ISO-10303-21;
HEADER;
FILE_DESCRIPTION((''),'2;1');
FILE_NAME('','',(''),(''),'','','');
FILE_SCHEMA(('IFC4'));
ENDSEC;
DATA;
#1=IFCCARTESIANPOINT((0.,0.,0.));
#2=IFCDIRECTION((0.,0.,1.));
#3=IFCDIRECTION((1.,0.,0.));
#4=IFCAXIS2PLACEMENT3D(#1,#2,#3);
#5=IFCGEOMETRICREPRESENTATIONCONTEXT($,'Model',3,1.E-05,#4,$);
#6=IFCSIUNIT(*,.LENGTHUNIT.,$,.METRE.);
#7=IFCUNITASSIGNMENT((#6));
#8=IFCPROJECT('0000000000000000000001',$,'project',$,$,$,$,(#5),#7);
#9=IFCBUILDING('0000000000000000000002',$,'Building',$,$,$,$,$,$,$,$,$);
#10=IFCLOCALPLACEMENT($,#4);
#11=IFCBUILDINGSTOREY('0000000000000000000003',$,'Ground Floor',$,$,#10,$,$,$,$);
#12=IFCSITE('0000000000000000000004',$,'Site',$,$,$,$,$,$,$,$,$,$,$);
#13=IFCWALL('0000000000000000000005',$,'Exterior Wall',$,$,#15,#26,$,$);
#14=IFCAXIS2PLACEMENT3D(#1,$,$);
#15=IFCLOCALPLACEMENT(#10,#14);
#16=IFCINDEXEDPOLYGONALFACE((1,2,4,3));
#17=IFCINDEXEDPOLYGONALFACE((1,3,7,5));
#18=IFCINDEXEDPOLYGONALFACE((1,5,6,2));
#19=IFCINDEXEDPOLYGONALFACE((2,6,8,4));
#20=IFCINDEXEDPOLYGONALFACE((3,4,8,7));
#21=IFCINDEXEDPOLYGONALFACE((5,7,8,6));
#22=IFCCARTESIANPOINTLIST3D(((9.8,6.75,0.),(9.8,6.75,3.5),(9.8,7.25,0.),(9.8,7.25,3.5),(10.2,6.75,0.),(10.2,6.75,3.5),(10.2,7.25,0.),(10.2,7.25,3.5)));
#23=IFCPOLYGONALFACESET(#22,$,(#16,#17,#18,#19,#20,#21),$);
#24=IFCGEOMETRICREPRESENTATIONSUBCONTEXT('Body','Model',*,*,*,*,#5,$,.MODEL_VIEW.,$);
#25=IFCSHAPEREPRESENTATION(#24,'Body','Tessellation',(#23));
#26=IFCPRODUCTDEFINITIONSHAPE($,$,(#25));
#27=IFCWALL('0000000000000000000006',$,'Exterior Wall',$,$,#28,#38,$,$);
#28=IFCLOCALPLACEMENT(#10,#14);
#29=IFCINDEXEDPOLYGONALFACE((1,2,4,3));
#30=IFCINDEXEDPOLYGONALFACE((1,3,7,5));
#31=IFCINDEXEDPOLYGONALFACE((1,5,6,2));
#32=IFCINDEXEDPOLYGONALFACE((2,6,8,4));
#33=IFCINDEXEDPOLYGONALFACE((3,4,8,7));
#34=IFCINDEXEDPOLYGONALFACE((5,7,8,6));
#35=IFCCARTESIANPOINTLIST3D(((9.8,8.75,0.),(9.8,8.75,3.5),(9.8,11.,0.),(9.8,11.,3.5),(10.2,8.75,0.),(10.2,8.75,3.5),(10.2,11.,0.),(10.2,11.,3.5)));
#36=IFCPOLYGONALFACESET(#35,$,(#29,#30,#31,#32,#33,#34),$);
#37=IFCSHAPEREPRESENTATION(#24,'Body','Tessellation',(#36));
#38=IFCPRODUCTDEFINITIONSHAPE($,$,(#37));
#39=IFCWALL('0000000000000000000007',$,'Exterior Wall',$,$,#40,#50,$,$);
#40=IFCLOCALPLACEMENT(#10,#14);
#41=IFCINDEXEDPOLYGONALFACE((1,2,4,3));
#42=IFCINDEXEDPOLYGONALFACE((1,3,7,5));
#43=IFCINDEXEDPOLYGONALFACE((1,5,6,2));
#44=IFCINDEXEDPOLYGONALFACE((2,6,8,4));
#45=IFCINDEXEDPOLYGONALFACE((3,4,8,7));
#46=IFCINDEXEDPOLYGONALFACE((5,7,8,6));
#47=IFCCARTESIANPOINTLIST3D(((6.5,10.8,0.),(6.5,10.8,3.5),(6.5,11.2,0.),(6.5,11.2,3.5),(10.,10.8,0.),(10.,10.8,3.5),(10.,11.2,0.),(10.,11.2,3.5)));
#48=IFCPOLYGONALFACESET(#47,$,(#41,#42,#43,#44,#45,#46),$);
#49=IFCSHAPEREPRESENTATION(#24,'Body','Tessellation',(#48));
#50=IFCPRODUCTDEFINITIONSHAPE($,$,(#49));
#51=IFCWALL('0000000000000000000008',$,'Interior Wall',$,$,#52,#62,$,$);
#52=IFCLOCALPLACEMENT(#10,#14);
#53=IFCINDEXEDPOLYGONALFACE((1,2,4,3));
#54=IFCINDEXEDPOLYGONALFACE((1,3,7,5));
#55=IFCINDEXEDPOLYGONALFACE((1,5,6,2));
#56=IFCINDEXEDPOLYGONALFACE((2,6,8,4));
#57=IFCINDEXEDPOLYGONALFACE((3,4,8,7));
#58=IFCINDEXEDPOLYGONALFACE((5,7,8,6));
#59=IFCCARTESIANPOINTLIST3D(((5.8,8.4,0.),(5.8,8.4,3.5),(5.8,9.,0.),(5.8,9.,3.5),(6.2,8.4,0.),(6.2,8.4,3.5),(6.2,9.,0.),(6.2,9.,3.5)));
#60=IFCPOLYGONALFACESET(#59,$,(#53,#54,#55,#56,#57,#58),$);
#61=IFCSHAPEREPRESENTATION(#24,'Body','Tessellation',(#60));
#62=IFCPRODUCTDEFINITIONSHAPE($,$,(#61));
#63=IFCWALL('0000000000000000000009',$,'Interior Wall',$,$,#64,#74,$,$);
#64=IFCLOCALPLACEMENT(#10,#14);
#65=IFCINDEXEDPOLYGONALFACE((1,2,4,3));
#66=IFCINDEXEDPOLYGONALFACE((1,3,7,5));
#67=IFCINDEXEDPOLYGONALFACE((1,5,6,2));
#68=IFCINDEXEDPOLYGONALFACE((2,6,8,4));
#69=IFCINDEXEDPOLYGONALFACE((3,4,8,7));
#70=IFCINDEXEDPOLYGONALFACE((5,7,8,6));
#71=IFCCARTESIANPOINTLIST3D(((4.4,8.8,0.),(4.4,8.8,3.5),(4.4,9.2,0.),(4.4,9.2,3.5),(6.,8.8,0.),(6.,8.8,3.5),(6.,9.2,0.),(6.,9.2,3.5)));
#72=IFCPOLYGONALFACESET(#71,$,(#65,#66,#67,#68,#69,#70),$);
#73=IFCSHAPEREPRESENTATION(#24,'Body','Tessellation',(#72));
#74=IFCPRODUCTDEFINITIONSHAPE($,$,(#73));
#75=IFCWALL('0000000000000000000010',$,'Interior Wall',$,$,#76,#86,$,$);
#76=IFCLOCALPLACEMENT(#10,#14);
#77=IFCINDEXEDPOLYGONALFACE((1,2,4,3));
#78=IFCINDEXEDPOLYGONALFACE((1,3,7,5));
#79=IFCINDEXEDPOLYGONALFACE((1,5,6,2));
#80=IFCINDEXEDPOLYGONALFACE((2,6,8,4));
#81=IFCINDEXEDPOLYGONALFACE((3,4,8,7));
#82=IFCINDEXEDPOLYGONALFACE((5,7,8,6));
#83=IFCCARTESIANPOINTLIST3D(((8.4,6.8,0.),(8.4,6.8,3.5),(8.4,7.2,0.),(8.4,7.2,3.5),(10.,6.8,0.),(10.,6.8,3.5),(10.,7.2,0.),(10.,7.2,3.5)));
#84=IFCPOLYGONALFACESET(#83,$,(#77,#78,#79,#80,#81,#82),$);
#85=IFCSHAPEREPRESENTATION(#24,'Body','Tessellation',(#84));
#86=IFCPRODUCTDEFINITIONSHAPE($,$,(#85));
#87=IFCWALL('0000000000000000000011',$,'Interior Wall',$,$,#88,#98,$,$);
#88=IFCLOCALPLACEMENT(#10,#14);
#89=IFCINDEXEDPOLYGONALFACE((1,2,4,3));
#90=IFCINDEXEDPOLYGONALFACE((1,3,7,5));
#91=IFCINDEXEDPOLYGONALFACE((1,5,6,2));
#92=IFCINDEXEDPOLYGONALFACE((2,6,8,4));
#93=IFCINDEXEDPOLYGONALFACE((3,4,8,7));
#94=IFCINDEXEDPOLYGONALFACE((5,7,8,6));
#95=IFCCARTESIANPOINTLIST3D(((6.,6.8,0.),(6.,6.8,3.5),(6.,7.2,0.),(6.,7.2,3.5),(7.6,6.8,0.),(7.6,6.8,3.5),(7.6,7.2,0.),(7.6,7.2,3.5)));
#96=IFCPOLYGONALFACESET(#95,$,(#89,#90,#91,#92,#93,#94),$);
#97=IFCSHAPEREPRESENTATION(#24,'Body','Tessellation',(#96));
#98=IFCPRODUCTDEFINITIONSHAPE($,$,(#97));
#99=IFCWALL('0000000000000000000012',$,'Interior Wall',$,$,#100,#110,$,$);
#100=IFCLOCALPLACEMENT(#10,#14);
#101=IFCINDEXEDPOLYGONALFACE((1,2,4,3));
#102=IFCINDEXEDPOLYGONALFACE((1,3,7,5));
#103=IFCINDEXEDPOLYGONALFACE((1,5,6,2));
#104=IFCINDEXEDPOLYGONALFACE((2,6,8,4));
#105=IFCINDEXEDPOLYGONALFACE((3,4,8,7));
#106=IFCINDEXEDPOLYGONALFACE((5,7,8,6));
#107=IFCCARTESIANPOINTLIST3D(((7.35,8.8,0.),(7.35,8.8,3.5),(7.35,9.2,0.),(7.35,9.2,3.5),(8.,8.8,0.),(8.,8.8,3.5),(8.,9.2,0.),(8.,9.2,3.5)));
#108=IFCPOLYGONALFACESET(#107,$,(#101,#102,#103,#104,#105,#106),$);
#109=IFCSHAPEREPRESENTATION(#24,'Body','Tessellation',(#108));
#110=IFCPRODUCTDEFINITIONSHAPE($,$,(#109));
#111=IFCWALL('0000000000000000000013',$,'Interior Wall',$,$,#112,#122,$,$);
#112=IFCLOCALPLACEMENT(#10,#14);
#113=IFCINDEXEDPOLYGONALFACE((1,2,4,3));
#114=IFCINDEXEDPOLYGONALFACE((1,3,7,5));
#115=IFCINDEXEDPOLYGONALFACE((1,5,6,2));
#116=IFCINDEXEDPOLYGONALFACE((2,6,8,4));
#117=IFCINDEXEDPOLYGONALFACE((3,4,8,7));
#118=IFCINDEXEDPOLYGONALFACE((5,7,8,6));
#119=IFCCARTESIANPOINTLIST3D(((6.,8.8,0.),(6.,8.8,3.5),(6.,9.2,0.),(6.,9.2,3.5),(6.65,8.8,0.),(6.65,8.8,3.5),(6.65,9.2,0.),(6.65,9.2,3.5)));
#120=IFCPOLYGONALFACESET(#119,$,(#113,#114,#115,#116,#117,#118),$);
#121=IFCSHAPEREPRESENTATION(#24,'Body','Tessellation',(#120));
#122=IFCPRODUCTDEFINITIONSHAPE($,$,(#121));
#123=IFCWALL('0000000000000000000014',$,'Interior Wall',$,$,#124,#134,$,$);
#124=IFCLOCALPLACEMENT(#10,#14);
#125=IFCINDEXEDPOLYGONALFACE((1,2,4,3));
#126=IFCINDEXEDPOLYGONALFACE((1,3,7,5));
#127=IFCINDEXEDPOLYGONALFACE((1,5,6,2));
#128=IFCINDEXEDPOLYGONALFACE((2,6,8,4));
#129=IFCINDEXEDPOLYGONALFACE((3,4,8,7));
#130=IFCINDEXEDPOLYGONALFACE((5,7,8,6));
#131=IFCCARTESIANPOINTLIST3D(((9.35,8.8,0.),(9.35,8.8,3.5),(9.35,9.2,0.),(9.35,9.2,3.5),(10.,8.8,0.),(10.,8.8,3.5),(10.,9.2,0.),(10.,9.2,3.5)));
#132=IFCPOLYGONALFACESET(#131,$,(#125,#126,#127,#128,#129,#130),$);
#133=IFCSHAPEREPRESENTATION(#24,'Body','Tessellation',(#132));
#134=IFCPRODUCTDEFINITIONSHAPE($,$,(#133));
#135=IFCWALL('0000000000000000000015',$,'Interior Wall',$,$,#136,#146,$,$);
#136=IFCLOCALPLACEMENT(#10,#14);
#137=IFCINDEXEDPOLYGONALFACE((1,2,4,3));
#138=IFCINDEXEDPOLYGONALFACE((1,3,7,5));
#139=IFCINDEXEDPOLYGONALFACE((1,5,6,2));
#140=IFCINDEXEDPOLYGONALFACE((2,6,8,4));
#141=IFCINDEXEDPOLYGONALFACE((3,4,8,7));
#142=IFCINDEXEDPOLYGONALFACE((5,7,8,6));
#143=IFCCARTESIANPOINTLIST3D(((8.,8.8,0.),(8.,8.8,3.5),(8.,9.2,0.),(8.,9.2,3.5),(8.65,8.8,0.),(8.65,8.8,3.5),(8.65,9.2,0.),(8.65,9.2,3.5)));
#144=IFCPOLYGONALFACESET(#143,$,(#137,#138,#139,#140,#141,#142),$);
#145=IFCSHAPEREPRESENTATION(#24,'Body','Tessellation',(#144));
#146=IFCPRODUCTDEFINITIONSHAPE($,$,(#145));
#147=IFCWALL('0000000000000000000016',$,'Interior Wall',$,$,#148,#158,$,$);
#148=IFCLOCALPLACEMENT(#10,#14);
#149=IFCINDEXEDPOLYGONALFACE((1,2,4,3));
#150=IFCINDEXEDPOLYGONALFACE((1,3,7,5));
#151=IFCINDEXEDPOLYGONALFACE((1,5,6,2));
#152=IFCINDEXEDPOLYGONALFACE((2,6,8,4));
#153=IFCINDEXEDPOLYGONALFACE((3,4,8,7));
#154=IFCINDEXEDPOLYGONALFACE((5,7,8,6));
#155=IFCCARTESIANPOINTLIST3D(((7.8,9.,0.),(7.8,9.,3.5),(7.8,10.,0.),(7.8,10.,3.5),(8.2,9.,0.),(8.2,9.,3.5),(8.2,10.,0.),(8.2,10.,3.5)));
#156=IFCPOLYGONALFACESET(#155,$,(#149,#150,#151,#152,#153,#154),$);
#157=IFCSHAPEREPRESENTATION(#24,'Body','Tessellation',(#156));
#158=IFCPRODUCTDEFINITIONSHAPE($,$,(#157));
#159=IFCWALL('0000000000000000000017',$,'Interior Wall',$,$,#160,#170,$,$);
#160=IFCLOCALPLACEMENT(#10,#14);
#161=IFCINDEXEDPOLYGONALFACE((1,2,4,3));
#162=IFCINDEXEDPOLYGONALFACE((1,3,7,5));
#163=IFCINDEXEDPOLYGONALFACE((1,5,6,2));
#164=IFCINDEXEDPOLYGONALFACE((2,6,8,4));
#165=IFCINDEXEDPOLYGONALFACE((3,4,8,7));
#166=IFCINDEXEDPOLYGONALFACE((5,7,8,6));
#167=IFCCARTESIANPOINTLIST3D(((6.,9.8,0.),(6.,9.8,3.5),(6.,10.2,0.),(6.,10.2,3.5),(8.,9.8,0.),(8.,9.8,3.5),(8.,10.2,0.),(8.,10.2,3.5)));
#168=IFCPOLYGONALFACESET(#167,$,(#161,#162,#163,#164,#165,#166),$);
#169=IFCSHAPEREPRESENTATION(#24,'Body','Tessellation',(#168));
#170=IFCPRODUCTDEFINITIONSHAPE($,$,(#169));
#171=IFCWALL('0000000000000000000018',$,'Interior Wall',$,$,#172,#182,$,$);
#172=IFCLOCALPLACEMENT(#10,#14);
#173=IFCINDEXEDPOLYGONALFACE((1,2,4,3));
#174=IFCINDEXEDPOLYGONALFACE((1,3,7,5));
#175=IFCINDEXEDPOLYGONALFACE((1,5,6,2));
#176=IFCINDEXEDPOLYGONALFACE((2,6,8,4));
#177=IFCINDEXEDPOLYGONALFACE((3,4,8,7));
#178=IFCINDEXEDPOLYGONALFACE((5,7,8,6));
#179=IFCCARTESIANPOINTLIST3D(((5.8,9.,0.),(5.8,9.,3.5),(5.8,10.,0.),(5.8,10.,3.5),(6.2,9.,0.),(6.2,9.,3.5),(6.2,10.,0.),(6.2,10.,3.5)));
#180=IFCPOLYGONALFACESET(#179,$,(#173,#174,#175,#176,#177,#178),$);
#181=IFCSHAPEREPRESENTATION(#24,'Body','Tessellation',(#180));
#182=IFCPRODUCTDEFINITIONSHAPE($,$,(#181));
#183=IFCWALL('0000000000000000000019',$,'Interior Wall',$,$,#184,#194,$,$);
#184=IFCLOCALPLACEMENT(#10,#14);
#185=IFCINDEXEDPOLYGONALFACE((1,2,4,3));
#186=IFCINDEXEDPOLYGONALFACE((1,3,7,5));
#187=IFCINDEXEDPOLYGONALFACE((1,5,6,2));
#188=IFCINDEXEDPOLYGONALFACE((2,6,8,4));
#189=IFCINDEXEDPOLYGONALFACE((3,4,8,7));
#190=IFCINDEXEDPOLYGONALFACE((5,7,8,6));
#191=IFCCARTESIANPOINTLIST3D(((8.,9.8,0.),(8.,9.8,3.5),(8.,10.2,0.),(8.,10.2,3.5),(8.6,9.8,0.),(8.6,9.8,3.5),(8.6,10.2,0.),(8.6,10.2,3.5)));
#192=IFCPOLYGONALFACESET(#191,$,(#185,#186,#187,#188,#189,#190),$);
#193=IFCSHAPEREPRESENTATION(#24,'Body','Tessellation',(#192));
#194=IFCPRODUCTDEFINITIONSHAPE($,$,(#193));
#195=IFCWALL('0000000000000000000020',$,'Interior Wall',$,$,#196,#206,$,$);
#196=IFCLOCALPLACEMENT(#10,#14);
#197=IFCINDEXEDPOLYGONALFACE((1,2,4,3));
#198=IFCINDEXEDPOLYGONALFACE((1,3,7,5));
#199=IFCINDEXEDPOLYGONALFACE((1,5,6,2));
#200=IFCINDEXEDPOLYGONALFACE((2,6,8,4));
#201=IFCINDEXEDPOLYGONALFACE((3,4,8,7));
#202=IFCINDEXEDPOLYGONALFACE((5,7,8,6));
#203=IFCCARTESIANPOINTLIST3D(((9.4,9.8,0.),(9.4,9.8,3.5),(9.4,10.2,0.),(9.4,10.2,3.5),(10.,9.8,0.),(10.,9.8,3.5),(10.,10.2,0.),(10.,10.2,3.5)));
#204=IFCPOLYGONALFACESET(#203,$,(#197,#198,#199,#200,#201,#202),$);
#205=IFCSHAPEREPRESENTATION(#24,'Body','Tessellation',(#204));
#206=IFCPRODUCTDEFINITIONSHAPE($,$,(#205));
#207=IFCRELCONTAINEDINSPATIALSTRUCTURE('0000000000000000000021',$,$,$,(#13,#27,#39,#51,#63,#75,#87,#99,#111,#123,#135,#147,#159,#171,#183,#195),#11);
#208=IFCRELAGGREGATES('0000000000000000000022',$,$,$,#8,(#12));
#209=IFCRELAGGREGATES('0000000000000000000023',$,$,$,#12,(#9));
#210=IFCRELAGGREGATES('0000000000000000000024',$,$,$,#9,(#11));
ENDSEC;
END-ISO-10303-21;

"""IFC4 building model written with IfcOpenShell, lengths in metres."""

from ifc_helpers import new_model, si_unit, frame, origin_with_axes, place, context, subcontext, project, spatial, indexed_curve, outline, extrude, element, save


model = new_model("IFC4")

# Units and contexts
model_context = context("Model", 3, precision=1e-05, world=origin_with_axes())
body_context = subcontext(model_context, "Body", "Model", "MODEL_VIEW")
ifc_project = project(units=[si_unit("LENGTHUNIT", "METRE")], contexts=[model_context])

# Site, building, storey
site = spatial("IfcSite", under=ifc_project, Name="Site")
building = spatial("IfcBuilding", under=site, Name="Building")
storey_placement = place(None, origin_with_axes())
storey = spatial("IfcBuildingStorey", under=building, at=storey_placement, Name="Ground Floor")

# Walls
wall_1_placement = place(storey_placement, frame((10.0, 6.75, 0.0), z_axis=(0.0, 0.0, 1.0), x_axis=(0.0, 1.0, 0.0)))
element("IfcWall", 1, at=wall_1_placement, inside=storey, Name="Exterior Wall", context=body_context, shape_type="SweptSolid", body=[
    extrude(outline(indexed_curve([(0.0, 0.0), (0.0, 0.4), (0.5, 0.4), (0.5, 0.0), (0.0, 0.0)], self_intersect=False)), frame((0.0, -0.2, 0.0), z_axis=(0.0, 0.0, 1.0), x_axis=(1.0, 0.0, 0.0)), (0.0, 0.0, 1.0), 3.5),
])
wall_2_placement = place(storey_placement, frame((10.0, 8.75, 0.0), z_axis=(0.0, 0.0, 1.0), x_axis=(0.0, 1.0, 0.0)))
element("IfcWall", 2, at=wall_2_placement, inside=storey, Name="Exterior Wall", context=body_context, shape_type="SweptSolid", body=[
    extrude(outline(indexed_curve([(0.0, 0.0), (0.0, 0.4), (2.25, 0.4), (2.25, 0.0), (0.0, 0.0)], self_intersect=False)), frame((0.0, -0.2, 0.0), z_axis=(0.0, 0.0, 1.0), x_axis=(1.0, 0.0, 0.0)), (0.0, 0.0, 1.0), 3.5),
])
wall_3_placement = place(storey_placement, frame((10.0, 11.0, 0.0), z_axis=(0.0, 0.0, 1.0), x_axis=(-1.0, 0.0, 0.0)))
element("IfcWall", 3, at=wall_3_placement, inside=storey, Name="Exterior Wall", context=body_context, shape_type="SweptSolid", body=[
    extrude(outline(indexed_curve([(0.0, 0.0), (0.0, 0.4), (3.5, 0.4), (3.5, 0.0), (0.0, 0.0)], self_intersect=False)), frame((0.0, -0.2, 0.0), z_axis=(0.0, 0.0, 1.0), x_axis=(1.0, 0.0, 0.0)), (0.0, 0.0, 1.0), 3.5),
])
wall_4_placement = place(storey_placement, frame((6.0, 8.4, 0.0), z_axis=(0.0, 0.0, 1.0), x_axis=(0.0, 1.0, 0.0)))
element("IfcWall", 4, at=wall_4_placement, inside=storey, Name="Interior Wall", context=body_context, shape_type="SweptSolid", body=[
    extrude(outline(indexed_curve([(0.0, 0.0), (0.0, 0.4), (0.6, 0.4), (0.6, 0.0), (0.0, 0.0)], self_intersect=False)), frame((0.0, -0.2, 0.0), z_axis=(0.0, 0.0, 1.0), x_axis=(1.0, 0.0, 0.0)), (0.0, 0.0, 1.0), 3.5),
])
for number, where, z_axis, x_axis, name in (
    (5, (6.0, 9.0, 0.0), (0.0, 0.0, 1.0), (-1.0, 0.0, 0.0), "Interior Wall"),
    (6, (10.0, 7.0, 0.0), (0.0, 0.0, 1.0), (-1.0, 0.0, 0.0), "Interior Wall"),
    (7, (7.6, 7.0, 0.0), (0.0, 0.0, 1.0), (-1.0, 0.0, 0.0), "Interior Wall"),
):
    element("IfcWall", number, at=place(storey_placement, frame(where, z_axis=z_axis, x_axis=x_axis)), inside=storey, Name=name, context=body_context, shape_type="SweptSolid", body=[
        extrude(outline(indexed_curve([(0.0, 0.0), (0.0, 0.4), (1.6, 0.4), (1.6, 0.0), (0.0, 0.0)], self_intersect=False)), frame((0.0, -0.2, 0.0), z_axis=(0.0, 0.0, 1.0), x_axis=(1.0, 0.0, 0.0)), (0.0, 0.0, 1.0), 3.5),
    ])
for number, where, z_axis, x_axis, name in (
    (8, (8.0, 9.0, 0.0), (0.0, 0.0, 1.0), (-1.0, 0.0, 0.0), "Interior Wall"),
    (9, (6.65, 9.0, 0.0), (0.0, 0.0, 1.0), (-1.0, 0.0, 0.0), "Interior Wall"),
    (10, (10.0, 9.0, 0.0), (0.0, 0.0, 1.0), (-1.0, 0.0, 0.0), "Interior Wall"),
    (11, (8.65, 9.0, 0.0), (0.0, 0.0, 1.0), (-1.0, 0.0, 0.0), "Interior Wall"),
):
    element("IfcWall", number, at=place(storey_placement, frame(where, z_axis=z_axis, x_axis=x_axis)), inside=storey, Name=name, context=body_context, shape_type="SweptSolid", body=[
        extrude(outline(indexed_curve([(0.0, 0.0), (0.0, 0.4), (0.65, 0.4), (0.65, 0.0), (0.0, 0.0)], self_intersect=False)), frame((0.0, -0.2, 0.0), z_axis=(0.0, 0.0, 1.0), x_axis=(1.0, 0.0, 0.0)), (0.0, 0.0, 1.0), 3.5),
    ])
wall_5_placement = place(storey_placement, frame((8.0, 9.0, 0.0), z_axis=(0.0, 0.0, 1.0), x_axis=(0.0, 1.0, 0.0)))
element("IfcWall", 12, at=wall_5_placement, inside=storey, Name="Interior Wall", context=body_context, shape_type="SweptSolid", body=[
    extrude(outline(indexed_curve([(0.0, 0.0), (0.0, 0.4), (1.0, 0.4), (1.0, 0.0), (0.0, 0.0)], self_intersect=False)), frame((0.0, -0.2, 0.0), z_axis=(0.0, 0.0, 1.0), x_axis=(1.0, 0.0, 0.0)), (0.0, 0.0, 1.0), 3.5),
])
wall_6_placement = place(storey_placement, frame((8.0, 10.0, 0.0), z_axis=(0.0, 0.0, 1.0), x_axis=(-1.0, 0.0, 0.0)))
element("IfcWall", 13, at=wall_6_placement, inside=storey, Name="Interior Wall", context=body_context, shape_type="SweptSolid", body=[
    extrude(outline(indexed_curve([(0.0, 0.0), (0.0, 0.4), (2.0, 0.4), (2.0, 0.0), (0.0, 0.0)], self_intersect=False)), frame((0.0, -0.2, 0.0), z_axis=(0.0, 0.0, 1.0), x_axis=(1.0, 0.0, 0.0)), (0.0, 0.0, 1.0), 3.5),
])
wall_7_placement = place(storey_placement, frame((6.0, 10.0, 0.0), z_axis=(0.0, 0.0, 1.0), x_axis=(0.0, -1.0, 0.0)))
element("IfcWall", 14, at=wall_7_placement, inside=storey, Name="Interior Wall", context=body_context, shape_type="SweptSolid", body=[
    extrude(outline(indexed_curve([(0.0, 0.0), (0.0, 0.4), (1.0, 0.4), (1.0, 0.0), (0.0, 0.0)], self_intersect=False)), frame((0.0, -0.2, 0.0), z_axis=(0.0, 0.0, 1.0), x_axis=(1.0, 0.0, 0.0)), (0.0, 0.0, 1.0), 3.5),
])
for number, where, z_axis, x_axis, name in (
    (15, (8.0, 10.0, 0.0), (0.0, 0.0, 1.0), (1.0, 0.0, 0.0), "Interior Wall"),
    (16, (9.4, 10.0, 0.0), (0.0, 0.0, 1.0), (1.0, 0.0, 0.0), "Interior Wall"),
):
    element("IfcWall", number, at=place(storey_placement, frame(where, z_axis=z_axis, x_axis=x_axis)), inside=storey, Name=name, context=body_context, shape_type="SweptSolid", body=[
        extrude(outline(indexed_curve([(0.0, 0.0), (0.0, 0.4), (0.6, 0.4), (0.6, 0.0), (0.0, 0.0)], self_intersect=False)), frame((0.0, -0.2, 0.0), z_axis=(0.0, 0.0, 1.0), x_axis=(1.0, 0.0, 0.0)), (0.0, 0.0, 1.0), 3.5),
    ])

save(model, "model.ifc")
